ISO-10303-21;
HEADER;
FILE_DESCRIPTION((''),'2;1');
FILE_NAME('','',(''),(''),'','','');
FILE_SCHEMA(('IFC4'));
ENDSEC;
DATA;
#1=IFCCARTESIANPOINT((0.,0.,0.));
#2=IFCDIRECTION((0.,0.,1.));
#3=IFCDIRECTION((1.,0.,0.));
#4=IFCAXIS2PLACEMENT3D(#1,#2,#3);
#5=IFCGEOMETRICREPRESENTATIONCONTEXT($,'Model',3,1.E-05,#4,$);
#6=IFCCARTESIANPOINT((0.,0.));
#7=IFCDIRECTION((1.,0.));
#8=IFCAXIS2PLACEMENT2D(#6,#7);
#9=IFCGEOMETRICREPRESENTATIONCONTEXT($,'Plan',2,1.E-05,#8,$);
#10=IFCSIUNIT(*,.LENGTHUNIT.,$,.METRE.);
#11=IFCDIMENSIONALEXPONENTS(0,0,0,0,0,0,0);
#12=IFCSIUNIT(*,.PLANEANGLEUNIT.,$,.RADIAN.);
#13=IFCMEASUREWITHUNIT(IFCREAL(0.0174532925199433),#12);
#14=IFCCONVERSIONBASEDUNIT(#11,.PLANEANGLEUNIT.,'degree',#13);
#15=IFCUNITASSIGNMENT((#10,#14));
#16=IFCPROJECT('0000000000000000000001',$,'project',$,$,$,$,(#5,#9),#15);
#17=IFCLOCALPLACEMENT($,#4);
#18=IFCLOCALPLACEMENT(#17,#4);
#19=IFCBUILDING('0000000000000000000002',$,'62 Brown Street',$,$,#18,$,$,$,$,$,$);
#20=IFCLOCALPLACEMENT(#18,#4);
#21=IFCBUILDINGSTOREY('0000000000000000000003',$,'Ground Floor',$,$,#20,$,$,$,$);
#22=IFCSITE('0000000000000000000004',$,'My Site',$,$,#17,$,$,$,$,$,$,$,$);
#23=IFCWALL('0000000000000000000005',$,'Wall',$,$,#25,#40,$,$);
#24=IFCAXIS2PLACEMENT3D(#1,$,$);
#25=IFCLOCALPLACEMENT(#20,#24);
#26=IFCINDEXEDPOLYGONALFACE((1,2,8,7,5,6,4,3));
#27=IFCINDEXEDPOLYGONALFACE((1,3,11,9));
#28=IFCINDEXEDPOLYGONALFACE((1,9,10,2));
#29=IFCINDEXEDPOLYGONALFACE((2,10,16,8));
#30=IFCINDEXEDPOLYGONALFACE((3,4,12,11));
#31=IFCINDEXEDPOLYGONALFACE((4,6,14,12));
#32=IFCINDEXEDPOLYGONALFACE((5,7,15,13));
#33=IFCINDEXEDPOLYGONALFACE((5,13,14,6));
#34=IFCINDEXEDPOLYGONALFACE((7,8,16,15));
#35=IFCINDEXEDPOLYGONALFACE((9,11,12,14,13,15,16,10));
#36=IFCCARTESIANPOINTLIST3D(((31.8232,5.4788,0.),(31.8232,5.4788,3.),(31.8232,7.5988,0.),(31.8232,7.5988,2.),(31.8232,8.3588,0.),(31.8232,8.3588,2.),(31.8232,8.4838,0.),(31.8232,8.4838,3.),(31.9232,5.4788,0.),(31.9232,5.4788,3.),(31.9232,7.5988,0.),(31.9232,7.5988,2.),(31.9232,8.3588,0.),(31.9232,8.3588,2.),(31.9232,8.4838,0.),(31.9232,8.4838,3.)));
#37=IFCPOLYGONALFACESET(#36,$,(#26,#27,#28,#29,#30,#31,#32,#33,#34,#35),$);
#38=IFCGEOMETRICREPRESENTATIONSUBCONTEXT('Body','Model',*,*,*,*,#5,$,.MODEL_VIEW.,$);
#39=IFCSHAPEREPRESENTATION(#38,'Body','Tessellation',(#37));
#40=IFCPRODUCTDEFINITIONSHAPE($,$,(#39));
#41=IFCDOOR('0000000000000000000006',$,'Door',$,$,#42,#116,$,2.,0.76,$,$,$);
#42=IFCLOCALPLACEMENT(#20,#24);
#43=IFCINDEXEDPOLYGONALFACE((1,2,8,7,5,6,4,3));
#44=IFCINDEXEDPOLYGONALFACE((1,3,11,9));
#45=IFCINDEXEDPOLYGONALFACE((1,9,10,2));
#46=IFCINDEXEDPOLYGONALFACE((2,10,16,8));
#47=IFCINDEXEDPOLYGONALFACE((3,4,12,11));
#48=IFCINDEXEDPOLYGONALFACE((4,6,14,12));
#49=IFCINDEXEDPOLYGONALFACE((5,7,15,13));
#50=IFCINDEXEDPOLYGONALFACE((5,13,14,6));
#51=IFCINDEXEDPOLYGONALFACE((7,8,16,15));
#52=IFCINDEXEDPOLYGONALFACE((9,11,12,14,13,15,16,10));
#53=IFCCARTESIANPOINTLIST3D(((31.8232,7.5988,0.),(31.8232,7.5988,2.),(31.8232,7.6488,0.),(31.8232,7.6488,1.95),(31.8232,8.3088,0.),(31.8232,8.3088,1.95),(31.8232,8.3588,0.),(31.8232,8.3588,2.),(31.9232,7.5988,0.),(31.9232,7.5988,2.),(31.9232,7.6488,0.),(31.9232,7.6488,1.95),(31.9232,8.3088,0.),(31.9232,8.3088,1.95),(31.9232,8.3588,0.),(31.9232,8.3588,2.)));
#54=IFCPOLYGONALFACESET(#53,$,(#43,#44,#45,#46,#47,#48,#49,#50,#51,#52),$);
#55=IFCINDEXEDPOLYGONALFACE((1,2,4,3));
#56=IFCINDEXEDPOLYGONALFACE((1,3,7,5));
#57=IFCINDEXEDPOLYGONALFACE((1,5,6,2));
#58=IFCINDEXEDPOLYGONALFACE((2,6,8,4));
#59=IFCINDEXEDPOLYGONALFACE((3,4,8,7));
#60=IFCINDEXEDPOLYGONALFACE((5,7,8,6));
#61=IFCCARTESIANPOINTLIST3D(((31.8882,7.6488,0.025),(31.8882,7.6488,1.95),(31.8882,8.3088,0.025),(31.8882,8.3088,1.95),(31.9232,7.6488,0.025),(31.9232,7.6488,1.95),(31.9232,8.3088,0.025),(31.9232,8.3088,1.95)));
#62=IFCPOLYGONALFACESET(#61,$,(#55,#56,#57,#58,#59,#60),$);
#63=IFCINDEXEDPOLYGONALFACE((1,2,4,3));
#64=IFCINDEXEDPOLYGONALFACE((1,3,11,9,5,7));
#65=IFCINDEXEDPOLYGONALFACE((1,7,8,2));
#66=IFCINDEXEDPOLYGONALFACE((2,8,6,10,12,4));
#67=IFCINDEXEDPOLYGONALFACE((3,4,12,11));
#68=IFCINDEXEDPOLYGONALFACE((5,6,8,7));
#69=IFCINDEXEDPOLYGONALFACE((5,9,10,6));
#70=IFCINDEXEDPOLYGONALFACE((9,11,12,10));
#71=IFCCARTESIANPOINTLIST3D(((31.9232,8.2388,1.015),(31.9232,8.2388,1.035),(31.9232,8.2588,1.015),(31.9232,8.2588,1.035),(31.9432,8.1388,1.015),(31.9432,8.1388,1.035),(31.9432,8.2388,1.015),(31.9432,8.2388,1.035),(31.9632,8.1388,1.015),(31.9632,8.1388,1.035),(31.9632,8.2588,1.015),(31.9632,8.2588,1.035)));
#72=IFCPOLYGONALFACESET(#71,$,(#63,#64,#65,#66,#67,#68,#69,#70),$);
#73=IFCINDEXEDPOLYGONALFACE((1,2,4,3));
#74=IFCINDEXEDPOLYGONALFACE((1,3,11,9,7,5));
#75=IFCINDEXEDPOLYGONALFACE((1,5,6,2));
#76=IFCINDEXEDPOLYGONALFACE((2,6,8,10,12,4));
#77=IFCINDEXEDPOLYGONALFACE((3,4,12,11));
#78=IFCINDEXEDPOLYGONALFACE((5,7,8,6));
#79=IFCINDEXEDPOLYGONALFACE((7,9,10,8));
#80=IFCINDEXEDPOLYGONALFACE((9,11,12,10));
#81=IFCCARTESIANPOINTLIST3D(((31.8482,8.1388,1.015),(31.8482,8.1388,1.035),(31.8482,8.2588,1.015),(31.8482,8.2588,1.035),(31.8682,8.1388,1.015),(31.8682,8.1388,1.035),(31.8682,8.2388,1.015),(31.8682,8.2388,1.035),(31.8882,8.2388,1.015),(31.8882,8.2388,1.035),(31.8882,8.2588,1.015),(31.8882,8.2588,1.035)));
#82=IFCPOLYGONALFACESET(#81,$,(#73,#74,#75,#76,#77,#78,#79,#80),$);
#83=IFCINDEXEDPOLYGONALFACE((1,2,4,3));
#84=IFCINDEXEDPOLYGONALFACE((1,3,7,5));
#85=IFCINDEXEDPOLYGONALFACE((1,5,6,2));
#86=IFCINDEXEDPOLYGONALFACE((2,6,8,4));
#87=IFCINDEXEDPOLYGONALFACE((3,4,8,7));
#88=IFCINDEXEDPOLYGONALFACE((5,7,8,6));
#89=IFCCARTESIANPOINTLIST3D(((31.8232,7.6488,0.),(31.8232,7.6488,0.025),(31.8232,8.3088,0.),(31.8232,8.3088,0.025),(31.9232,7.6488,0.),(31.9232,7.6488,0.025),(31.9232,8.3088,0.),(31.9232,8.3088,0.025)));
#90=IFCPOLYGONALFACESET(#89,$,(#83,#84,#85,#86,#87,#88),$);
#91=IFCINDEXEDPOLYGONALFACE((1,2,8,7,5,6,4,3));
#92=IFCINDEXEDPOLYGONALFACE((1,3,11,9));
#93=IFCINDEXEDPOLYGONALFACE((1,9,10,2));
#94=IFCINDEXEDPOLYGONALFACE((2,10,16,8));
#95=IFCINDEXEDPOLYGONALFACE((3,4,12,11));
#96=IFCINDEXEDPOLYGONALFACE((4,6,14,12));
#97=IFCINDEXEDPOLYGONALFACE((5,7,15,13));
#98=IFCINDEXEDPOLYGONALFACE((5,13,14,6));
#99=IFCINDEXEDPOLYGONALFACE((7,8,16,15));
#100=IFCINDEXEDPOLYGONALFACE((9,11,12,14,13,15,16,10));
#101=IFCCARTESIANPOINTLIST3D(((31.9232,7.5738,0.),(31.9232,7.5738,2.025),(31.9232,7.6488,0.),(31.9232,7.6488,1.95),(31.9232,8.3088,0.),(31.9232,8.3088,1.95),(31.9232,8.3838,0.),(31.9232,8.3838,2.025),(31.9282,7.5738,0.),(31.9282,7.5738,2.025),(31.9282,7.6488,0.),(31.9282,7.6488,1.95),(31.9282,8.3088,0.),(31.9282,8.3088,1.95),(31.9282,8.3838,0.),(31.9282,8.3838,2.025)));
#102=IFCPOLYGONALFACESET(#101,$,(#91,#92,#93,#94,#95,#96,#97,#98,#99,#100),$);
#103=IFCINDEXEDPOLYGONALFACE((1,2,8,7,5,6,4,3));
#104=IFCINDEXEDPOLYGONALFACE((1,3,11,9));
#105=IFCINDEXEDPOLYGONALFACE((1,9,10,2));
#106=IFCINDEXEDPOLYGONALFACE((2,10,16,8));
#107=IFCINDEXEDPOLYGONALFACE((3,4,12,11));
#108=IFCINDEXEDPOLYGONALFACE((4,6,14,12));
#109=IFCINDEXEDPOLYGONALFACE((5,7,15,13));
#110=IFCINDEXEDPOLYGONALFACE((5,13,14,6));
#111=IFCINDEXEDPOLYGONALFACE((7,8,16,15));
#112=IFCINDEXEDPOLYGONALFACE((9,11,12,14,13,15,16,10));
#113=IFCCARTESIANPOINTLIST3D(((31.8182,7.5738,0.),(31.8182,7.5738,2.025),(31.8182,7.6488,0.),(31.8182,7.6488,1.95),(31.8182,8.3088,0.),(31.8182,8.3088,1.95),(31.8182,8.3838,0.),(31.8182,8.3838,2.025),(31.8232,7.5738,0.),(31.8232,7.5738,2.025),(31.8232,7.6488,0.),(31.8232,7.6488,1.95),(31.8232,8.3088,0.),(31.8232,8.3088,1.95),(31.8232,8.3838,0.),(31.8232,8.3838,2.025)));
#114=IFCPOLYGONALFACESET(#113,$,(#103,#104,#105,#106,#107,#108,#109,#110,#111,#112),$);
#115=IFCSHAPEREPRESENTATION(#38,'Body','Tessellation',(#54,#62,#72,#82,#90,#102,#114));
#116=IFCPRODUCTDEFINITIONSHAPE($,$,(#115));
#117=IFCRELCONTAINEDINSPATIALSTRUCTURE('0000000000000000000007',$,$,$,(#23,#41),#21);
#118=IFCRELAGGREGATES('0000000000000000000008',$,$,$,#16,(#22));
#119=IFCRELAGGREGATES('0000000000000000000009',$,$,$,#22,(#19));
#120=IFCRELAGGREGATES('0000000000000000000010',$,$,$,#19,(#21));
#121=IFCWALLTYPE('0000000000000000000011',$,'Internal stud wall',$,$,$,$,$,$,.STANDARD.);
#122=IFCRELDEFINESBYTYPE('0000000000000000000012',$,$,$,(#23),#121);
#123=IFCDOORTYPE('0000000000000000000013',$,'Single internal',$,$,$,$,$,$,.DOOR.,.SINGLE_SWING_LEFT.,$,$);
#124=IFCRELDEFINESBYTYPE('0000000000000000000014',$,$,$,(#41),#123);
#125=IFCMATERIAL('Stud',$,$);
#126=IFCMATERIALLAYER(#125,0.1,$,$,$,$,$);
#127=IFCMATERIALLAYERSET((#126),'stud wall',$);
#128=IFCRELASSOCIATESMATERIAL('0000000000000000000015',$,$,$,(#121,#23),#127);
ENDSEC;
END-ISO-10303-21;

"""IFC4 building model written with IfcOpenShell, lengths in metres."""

from ifc_helpers import new_model, entity, si_unit, converted_unit, frame, origin_with_axes, origin_2d_with_axis, place, context, subcontext, project, spatial, line, indexed_curve, outline, extrude, shape, source, transform, mapped, material, layer, layer_set, layer_usage, type_object, type_shapes, element, fill, save


model = new_model("IFC4")

# Units and contexts
model_context = context("Model", 3, precision=1e-05, world=origin_with_axes())
plan_context = context("Plan", 2, precision=1e-05, world=origin_2d_with_axis())
body_context_1 = subcontext(model_context, "Body", "Model", "MODEL_VIEW")
body_context_2 = subcontext(plan_context, "Body", "Plan", "PLAN_VIEW")
ifc_project = project(units=[si_unit("LENGTHUNIT", "METRE"), converted_unit("PLANEANGLEUNIT", "degree", entity("IfcReal", 0.0174532925199433), si_unit("PLANEANGLEUNIT", "RADIAN"), dimensions=[0, 0, 0, 0, 0, 0, 0])], contexts=[model_context, plan_context])

# Site, building, storey
site_placement = place(None, origin_with_axes())
site = spatial("IfcSite", under=ifc_project, at=site_placement, Name="My Site")
building_placement = place(site_placement, origin_with_axes())
building = spatial("IfcBuilding", under=site, at=building_placement, Name="62 Brown Street")
storey_placement = place(building_placement, origin_with_axes())
storey = spatial("IfcBuildingStorey", under=building, at=storey_placement, Name="Ground Floor")

# Shared definitions
ifc_material_1 = material(Name="Stud")
ifc_layer_1 = layer(ifc_material_1, 0.1)
ifc_layer_set_1 = layer_set([ifc_layer_1], Name="stud wall")
wall_type_1 = type_object("IfcWallType", Name="Internal stud wall", PredefinedType="STANDARD", material=ifc_layer_set_1)

# Wall, opening, door
ifc_layer_usage_1 = layer_usage(ifc_layer_set_1, "AXIS2", "POSITIVE", 0.0)
wall_1_placement = place(storey_placement, frame((31.9232, 5.4788, 0.0), z_axis=(0.0, 0.0, 1.0), x_axis=(0.000001, 1.0, 0.0)))
wall_1 = element("IfcWall", 1, at=wall_1_placement, inside=storey, type_object=wall_type_1, material=ifc_layer_usage_1, Name="Wall", context=body_context_1, shape_type="SweptSolid", body=[
    extrude(outline(indexed_curve([(0.0, 0.0), (0.0, 0.1), (3.005, 0.1), (3.005, 0.0), (0.0, 0.0)], self_intersect=False)), origin_with_axes(), (0.0, 0.0, 1.0), 3.0),
])
shared_shape_1 = source(origin_with_axes(), body_context_1, "Body", "SweptSolid", [
    extrude(outline(indexed_curve([(0.0, 0.0), (0.76, 0.0), (0.76, 2.0), (0.0, 2.0)], segments=[line(1, 2, 3, 4, 1)])), frame((0.0, -0.6, 0.0), z_axis=(0.0, -1.0, 0.0), x_axis=(1.0, 0.0, 0.0)), (0.0, 0.0, -1.0), 1.2),
])
opening_1_placement = place(wall_1_placement, frame((2.12, 0.0, 0.0), z_axis=(0.0, 0.0, 1.0), x_axis=(1.0, 0.0, 0.0)))
opening_1 = element("IfcOpeningElement", 2, at=opening_1_placement, cuts=wall_1, PredefinedType="OPENING", context=body_context_1, shape_type="MappedRepresentation", body=[
    mapped(shared_shape_1, transform((0.0, 0.0, 0.0), x_axis=(1.0, 0.0, 0.0), y_axis=(0.0, 1.0, 0.0), z_axis=(0.0, 0.0, 1.0), scale=1.0)),
])
door_type_1 = type_object("IfcDoorType", Name="Single internal", OperationType="SINGLE_SWING_LEFT", PredefinedType="DOOR")
shared_shape_2 = source(origin_with_axes(), body_context_1, "Body", "SweptSolid", [
    extrude(outline(indexed_curve([(0.0, 0.0), (0.0, 2.0), (0.76, 2.0), (0.76, 0.0), (0.71, 0.0), (0.71, 1.95), (0.05, 1.95), (0.05, 0.0)], segments=[line(1, 2, 3, 4, 5, 6, 7, 8, 1)])), frame((0.0, 0.0, 0.0), z_axis=(0.0, -1.0, 0.0), x_axis=(1.0, 0.0, 0.0)), (0.0, 0.0, -1.0), 0.1),
    extrude(outline(indexed_curve([(0.0, 0.0), (0.66, 0.0), (0.66, 0.035), (0.0, 0.035)], segments=[line(1, 2, 3, 4, 1)])), frame((0.05, 0.0, 0.025), z_axis=(0.0, 0.0, 1.0), x_axis=(1.0, 0.0, 0.0)), (0.0, 0.0, 1.0), 1.925),
    extrude(outline(indexed_curve([(0.0, 0.0), (0.0, -0.04), (-0.12, -0.04), (-0.12, -0.02), (-0.02, -0.02), (-0.02, 0.0)], segments=[line(1, 2, 3, 4, 5, 6, 1)])), frame((0.66, 0.0, 1.015), z_axis=(0.0, 0.0, 1.0), x_axis=(1.0, 0.0, 0.0)), (0.0, 0.0, 1.0), 0.02),
    extrude(outline(indexed_curve([(0.0, 0.0), (0.0, 0.04), (-0.12, 0.04), (-0.12, 0.02), (-0.02, 0.02), (-0.02, 0.0)], segments=[line(1, 2, 3, 4, 5, 6, 1)])), frame((0.66, 0.035, 1.015), z_axis=(0.0, 0.0, 1.0), x_axis=(1.0, 0.0, 0.0)), (0.0, 0.0, 1.0), 0.02),
    extrude(outline(indexed_curve([(0.0, 0.0), (0.66, 0.0), (0.66, 0.1), (0.0, 0.1)], segments=[line(1, 2, 3, 4, 1)])), frame((0.05, 0.0, 0.0), z_axis=(0.0, 0.0, 1.0), x_axis=(1.0, 0.0, 0.0)), (0.0, 0.0, 1.0), 0.025),
    extrude(outline(indexed_curve([(0.0, 0.0), (0.0, 2.025), (0.81, 2.025), (0.81, 0.0), (0.735, 0.0), (0.735, 1.95), (0.075, 1.95), (0.075, 0.0)], segments=[line(1, 2, 3, 4, 5, 6, 7, 8, 1)])), frame((-0.025, -0.005, 0.0), z_axis=(0.0, -1.0, 0.0), x_axis=(1.0, 0.0, 0.0)), (0.0, 0.0, -1.0), 0.005),
    extrude(outline(indexed_curve([(0.0, 0.0), (0.0, 2.025), (0.81, 2.025), (0.81, 0.0), (0.735, 0.0), (0.735, 1.95), (0.075, 1.95), (0.075, 0.0)], segments=[line(1, 2, 3, 4, 5, 6, 7, 8, 1)])), frame((-0.025, 0.1, 0.0), z_axis=(0.0, -1.0, 0.0), x_axis=(1.0, 0.0, 0.0)), (0.0, 0.0, -1.0), 0.005),
])
shared_shape_3 = source(origin_with_axes(), body_context_2, "Body", "Curve2D", [
    entity("IfcIndexedPolyCurve", entity("IfcCartesianPointList2D", [[0.0, 0.0], [0.05, 0.0], [0.05, 0.1], [0.0, 0.1]]), [entity("IfcLineIndex", [1, 2, 3, 4, 1])]),
    entity("IfcIndexedPolyCurve", entity("IfcCartesianPointList2D", [[0.76, 0.0], [0.71, 0.0], [0.71, 0.1], [0.76, 0.1]]), [entity("IfcLineIndex", [1, 2, 3, 4, 1])]),
    entity("IfcTrimmedCurve", entity("IfcEllipse", entity("IfcAxis2Placement2D", entity("IfcCartesianPoint", [0.085, 0.1]), entity("IfcDirection", [1.0, 0.0])), 0.625, 0.66), [entity("IfcCartesianPoint", [0.71, 0.1])], [entity("IfcCartesianPoint", [0.085, 0.76])], True, "CARTESIAN"),
    entity("IfcIndexedPolyCurve", entity("IfcCartesianPointList2D", [[0.05, 0.1], [0.085, 0.1], [0.085, 0.76], [0.05, 0.76]]), [entity("IfcLineIndex", [1, 2, 3, 4, 1])]),
])
type_shapes(door_type_1, [shared_shape_2, shared_shape_3])
door_1_placement = place(opening_1_placement, frame((0.0, 0.0, 0.0), z_axis=(0.0, 0.0, 1.0), x_axis=(1.0, 0.0, 0.0)))
door_1 = element("IfcDoor", 3, at=door_1_placement, inside=storey, type_object=door_type_1, Name="Door", OverallHeight=2.0, OverallWidth=0.76, shapes=[
    shape(body_context_1, "Body", "MappedRepresentation", [mapped(shared_shape_2, transform((0.0, 0.0, 0.0), x_axis=(1.0, 0.0, 0.0), y_axis=(0.0, 1.0, 0.0), z_axis=(0.0, 0.0, 1.0), scale=1.0))]),
    shape(body_context_2, "Body", "MappedRepresentation", [mapped(shared_shape_3, transform((0.0, 0.0, 0.0), x_axis=(1.0, 0.0, 0.0), y_axis=(0.0, 1.0, 0.0), z_axis=(0.0, 0.0, 1.0), scale=1.0))]),
])
fill(opening_1, door_1)

save(model, "model.ifc")
